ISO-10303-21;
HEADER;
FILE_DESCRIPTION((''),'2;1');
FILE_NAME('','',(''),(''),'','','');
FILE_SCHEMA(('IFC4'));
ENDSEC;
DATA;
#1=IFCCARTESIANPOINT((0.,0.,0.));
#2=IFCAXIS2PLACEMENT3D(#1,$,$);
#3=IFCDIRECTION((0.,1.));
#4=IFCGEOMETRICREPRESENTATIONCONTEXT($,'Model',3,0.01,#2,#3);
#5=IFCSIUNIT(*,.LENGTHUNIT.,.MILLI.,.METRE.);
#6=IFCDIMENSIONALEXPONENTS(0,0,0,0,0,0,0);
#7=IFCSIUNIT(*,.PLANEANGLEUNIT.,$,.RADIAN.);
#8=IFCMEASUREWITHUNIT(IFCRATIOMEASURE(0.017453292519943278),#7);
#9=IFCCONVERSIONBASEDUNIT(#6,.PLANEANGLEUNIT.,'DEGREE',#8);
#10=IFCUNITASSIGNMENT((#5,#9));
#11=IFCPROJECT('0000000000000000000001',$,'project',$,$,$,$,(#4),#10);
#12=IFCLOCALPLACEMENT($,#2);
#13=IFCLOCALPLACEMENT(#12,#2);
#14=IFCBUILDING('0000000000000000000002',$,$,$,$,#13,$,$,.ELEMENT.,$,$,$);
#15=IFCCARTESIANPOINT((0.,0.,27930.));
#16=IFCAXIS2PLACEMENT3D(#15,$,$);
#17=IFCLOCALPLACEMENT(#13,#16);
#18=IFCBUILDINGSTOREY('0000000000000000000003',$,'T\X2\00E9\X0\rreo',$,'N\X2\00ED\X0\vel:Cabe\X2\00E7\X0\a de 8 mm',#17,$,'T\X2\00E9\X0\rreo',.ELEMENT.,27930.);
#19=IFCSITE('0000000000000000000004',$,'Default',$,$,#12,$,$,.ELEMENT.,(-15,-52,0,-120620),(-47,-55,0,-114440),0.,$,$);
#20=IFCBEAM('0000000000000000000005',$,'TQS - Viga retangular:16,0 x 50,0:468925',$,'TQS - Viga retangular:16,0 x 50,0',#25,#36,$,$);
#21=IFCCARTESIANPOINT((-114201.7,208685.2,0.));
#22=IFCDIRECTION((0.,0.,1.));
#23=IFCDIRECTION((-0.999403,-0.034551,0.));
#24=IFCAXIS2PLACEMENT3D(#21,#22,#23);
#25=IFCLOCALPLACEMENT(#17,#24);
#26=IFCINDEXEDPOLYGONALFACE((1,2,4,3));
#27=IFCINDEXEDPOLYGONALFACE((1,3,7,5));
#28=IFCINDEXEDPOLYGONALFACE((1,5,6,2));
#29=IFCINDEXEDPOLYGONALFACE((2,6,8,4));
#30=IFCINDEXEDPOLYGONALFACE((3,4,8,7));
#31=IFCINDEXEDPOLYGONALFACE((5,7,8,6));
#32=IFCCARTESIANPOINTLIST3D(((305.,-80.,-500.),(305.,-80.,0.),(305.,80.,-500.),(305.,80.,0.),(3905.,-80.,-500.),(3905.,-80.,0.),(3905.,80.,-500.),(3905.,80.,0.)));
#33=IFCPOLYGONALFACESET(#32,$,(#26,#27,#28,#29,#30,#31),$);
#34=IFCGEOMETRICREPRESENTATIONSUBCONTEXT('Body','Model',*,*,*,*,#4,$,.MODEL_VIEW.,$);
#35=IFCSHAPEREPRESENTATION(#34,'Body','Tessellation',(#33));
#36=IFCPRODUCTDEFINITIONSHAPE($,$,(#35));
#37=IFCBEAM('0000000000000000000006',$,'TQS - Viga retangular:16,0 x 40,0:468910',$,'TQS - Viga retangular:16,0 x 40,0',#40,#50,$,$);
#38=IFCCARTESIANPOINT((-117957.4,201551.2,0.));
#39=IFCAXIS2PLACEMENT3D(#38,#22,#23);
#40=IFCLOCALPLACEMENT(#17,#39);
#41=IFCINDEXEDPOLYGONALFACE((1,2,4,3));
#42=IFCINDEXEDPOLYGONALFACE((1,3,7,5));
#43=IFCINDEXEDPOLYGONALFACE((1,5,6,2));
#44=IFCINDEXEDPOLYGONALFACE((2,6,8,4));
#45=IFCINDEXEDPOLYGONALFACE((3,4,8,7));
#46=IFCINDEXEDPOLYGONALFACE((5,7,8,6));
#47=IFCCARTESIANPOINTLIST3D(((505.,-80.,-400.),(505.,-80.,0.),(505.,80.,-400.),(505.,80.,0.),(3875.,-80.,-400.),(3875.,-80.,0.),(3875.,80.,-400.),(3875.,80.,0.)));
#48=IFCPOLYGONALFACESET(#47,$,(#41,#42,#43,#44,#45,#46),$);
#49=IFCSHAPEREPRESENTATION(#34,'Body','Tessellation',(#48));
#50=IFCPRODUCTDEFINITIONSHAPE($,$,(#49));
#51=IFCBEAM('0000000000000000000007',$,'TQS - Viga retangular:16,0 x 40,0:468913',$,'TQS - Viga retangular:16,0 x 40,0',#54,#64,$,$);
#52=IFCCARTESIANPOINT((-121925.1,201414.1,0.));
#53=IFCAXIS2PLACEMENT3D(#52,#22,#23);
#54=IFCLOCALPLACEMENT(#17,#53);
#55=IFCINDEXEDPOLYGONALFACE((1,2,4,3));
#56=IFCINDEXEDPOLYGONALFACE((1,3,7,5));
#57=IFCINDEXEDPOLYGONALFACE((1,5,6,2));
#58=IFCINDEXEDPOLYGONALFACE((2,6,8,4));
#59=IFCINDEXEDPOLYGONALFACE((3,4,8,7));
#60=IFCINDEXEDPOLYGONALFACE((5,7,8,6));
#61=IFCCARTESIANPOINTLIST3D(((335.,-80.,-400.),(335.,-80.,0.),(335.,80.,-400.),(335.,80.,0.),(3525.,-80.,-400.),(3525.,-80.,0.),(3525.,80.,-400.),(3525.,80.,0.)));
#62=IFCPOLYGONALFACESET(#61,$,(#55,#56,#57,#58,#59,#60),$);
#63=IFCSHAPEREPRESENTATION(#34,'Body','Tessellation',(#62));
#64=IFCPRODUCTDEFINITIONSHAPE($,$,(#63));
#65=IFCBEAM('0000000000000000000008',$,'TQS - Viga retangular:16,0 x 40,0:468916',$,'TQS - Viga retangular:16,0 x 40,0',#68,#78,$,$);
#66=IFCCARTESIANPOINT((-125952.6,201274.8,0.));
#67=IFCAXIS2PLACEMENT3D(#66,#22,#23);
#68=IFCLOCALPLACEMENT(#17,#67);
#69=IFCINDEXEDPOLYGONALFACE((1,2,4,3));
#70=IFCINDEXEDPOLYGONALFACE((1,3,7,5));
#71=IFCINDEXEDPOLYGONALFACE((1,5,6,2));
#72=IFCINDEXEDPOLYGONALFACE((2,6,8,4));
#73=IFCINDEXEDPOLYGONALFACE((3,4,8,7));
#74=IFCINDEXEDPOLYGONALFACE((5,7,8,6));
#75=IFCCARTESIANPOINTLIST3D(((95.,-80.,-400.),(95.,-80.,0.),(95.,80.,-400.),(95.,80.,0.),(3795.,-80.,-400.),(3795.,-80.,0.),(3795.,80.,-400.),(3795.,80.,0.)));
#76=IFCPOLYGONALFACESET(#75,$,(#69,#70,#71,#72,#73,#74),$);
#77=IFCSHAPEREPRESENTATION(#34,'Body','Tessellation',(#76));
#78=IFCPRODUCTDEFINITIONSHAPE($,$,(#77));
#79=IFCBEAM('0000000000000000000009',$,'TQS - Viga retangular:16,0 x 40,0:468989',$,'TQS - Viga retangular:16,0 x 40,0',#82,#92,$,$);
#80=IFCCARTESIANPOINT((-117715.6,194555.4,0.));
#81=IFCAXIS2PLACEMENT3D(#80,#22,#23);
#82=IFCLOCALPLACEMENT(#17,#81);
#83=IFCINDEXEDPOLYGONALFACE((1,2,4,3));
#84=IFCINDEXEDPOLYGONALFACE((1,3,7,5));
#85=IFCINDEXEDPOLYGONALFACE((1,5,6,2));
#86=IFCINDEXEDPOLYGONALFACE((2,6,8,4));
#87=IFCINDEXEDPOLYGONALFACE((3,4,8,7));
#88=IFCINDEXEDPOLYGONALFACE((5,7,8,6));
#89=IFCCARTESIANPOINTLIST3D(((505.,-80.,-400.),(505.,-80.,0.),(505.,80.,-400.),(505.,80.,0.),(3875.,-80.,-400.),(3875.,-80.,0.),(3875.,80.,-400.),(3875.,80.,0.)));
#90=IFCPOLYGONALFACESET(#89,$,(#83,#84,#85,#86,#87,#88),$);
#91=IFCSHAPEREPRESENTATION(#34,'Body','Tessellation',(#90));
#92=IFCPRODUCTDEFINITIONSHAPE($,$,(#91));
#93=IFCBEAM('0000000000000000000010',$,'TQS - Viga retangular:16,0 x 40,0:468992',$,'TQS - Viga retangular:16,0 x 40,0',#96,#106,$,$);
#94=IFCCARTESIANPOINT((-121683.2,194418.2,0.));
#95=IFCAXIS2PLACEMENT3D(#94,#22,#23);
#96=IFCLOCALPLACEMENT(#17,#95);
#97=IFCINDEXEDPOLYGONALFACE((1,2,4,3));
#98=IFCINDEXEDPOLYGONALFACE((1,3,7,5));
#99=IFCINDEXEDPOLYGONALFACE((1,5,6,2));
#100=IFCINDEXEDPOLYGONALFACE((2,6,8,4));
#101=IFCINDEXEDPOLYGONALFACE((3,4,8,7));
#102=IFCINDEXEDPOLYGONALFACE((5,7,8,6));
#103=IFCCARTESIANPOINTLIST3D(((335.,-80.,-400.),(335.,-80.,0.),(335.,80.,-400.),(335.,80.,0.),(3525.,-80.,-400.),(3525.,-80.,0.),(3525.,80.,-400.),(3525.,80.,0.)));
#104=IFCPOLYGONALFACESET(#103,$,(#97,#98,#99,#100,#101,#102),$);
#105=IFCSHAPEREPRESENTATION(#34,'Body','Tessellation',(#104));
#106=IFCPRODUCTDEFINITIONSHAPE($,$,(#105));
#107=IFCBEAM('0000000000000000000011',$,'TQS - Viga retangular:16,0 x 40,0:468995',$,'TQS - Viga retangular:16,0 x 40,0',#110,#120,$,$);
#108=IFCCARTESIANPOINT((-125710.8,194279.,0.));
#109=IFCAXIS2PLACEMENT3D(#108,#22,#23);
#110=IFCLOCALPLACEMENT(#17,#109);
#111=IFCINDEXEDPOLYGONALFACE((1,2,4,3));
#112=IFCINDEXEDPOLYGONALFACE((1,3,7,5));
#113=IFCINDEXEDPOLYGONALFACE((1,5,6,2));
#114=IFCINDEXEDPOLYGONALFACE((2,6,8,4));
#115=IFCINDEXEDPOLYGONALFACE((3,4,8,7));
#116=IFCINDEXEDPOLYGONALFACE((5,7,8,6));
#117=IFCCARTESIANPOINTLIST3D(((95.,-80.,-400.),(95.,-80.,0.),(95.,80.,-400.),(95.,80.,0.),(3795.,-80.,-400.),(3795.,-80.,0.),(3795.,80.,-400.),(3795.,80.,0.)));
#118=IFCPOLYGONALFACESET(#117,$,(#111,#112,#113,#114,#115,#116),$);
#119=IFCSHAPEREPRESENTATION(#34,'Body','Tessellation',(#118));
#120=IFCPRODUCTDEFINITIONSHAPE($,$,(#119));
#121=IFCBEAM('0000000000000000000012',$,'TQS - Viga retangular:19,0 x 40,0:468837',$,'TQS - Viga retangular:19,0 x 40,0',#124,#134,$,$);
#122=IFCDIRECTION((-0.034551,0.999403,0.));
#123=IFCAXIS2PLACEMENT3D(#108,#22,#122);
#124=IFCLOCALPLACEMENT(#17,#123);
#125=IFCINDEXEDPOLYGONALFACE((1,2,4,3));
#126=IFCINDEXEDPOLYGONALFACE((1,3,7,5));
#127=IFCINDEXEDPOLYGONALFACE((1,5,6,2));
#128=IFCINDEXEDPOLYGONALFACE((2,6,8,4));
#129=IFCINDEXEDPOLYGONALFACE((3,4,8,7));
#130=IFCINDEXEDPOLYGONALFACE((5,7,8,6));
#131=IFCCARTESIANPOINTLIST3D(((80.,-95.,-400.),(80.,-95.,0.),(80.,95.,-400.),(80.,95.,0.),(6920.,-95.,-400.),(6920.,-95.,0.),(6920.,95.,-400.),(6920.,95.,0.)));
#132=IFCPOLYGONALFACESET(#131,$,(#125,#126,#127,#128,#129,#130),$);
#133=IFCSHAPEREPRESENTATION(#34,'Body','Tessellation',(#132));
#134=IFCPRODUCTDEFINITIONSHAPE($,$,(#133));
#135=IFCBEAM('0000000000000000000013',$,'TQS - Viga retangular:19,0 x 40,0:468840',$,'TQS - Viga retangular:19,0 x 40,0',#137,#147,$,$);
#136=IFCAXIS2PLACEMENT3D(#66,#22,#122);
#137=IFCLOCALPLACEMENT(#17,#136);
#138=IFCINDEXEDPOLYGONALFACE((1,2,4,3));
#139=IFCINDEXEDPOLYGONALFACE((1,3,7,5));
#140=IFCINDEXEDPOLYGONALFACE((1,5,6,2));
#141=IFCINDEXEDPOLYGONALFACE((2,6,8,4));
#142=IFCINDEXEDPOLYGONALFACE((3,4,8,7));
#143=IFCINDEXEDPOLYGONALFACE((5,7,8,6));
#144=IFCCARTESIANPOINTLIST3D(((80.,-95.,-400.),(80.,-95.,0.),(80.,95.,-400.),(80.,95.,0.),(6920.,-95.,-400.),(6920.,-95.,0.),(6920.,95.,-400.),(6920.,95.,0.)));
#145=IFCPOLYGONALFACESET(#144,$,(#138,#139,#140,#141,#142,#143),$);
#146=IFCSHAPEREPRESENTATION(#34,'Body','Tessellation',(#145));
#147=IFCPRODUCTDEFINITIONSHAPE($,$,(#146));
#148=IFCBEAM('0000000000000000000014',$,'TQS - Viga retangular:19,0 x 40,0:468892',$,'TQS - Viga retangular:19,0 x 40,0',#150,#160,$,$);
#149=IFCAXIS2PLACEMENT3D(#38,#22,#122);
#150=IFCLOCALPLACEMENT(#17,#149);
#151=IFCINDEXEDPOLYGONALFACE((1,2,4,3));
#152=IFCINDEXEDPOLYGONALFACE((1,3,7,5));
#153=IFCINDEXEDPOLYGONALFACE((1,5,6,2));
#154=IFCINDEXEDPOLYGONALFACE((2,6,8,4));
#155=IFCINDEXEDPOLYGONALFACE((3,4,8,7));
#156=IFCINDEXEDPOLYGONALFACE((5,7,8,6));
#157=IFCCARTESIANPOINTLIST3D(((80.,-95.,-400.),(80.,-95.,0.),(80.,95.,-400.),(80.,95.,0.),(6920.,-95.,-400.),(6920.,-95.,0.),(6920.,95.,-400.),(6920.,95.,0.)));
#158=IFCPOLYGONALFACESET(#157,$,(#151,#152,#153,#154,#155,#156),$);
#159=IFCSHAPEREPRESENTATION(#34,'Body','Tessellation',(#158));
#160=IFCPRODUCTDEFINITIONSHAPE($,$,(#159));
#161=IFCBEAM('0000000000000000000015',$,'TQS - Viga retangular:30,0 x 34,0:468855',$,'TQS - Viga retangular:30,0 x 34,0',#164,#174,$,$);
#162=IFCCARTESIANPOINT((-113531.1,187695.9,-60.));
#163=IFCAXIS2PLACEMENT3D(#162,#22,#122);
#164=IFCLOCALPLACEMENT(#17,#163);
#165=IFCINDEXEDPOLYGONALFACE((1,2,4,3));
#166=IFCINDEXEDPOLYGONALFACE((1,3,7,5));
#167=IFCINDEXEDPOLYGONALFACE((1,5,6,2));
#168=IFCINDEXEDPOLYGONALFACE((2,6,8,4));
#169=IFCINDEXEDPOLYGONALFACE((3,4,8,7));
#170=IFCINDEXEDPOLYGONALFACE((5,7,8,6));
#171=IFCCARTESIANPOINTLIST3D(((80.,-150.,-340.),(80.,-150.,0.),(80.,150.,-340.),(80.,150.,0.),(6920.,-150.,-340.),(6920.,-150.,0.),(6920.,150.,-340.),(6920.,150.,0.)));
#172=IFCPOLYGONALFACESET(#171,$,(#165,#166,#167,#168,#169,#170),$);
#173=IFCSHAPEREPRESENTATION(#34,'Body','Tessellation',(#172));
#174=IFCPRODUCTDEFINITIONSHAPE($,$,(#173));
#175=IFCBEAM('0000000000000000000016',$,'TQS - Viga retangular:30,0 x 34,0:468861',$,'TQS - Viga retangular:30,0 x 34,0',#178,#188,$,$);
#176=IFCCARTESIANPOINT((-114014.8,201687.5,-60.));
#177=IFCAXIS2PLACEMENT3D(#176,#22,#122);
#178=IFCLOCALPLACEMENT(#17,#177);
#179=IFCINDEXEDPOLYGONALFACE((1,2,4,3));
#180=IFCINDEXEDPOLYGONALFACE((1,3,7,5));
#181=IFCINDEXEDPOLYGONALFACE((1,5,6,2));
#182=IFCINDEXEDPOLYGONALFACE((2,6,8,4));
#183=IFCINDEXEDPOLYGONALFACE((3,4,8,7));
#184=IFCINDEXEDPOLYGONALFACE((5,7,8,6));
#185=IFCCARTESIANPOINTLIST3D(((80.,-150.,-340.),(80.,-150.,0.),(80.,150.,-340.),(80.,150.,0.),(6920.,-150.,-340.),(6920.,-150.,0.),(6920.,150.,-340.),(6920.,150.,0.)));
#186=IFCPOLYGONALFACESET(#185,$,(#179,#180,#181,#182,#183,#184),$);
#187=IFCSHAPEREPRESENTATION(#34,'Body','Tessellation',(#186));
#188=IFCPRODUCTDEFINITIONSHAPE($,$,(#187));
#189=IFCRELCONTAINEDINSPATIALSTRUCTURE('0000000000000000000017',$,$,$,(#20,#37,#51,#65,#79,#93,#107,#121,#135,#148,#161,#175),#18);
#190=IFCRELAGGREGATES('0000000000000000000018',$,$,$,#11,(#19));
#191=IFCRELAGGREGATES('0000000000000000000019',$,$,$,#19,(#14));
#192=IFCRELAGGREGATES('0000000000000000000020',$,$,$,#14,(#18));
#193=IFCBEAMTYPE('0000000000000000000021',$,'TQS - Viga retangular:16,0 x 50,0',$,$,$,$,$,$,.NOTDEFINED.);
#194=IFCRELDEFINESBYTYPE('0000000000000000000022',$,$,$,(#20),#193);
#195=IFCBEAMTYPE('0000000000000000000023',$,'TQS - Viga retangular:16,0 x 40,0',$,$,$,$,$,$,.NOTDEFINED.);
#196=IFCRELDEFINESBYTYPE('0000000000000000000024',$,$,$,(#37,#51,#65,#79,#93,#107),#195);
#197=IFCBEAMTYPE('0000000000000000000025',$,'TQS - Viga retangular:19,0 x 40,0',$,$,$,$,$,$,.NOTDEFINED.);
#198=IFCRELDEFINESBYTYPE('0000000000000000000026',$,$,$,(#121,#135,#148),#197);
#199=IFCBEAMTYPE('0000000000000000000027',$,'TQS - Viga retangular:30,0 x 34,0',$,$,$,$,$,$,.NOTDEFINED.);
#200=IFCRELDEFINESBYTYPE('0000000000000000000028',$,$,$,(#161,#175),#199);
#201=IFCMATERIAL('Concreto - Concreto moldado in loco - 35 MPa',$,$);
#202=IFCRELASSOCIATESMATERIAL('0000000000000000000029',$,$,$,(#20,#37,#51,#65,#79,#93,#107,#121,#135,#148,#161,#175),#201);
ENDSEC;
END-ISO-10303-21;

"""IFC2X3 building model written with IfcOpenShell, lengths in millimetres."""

from ifc_helpers import new_model, entity, si_unit, converted_unit, direction, frame, frame_2d, origin, origin_2d_with_axis, place, context, subcontext, project, spatial, rectangle, extrude, material, type_object, element, save


model = new_model("IFC2X3")

# Units and contexts
model_context = context("Model", 3, precision=0.01, world=origin(), true_north=direction((0.0, 1.0)))
body_context = subcontext(model_context, "Body", "Model", "MODEL_VIEW")
ifc_project = project(units=[si_unit("LENGTHUNIT", "METRE", prefix="MILLI"), converted_unit("PLANEANGLEUNIT", "DEGREE", entity("IfcRatioMeasure", 0.017453292519943278), si_unit("PLANEANGLEUNIT", "RADIAN"), dimensions=[0, 0, 0, 0, 0, 0, 0])], contexts=[model_context])

# Site, building, storey
site_placement = place(None, origin())
site = spatial("IfcSite", under=ifc_project, at=site_placement, Name="Default", CompositionType="ELEMENT", RefLatitude=(-15, -52, 0, -120620), RefLongitude=(-47, -55, 0, -114440), RefElevation=0.0)
building_placement = place(site_placement, origin())
building = spatial("IfcBuilding", under=site, at=building_placement, CompositionType="ELEMENT")
storey_placement = place(building_placement, frame((0.0, 0.0, 27930.0)))
storey = spatial("IfcBuildingStorey", under=building, at=storey_placement, Name="Térreo", ObjectType="Nível:Cabeça de 8 mm", LongName="Térreo", CompositionType="ELEMENT", Elevation=27930.0)

# Beams
ifc_material_1 = material(Name="Concreto - Concreto moldado in loco - 35 MPa")
beam_type_1 = type_object("IfcBeamType", Name="TQS - Viga retangular:16,0 x 50,0", PredefinedType="NOTDEFINED")
beam_1_placement = place(storey_placement, frame((-114201.7, 208685.2, 0.0), z_axis=(0.0, 0.0, 1.0), x_axis=(-0.999403, -0.034551, 0.0)))
element("IfcBeam", 1, at=beam_1_placement, inside=storey, type_object=beam_type_1, material=ifc_material_1, Name="TQS - Viga retangular:16,0 x 50,0:468925", ObjectType="TQS - Viga retangular:16,0 x 50,0", context=body_context, shape_type="SweptSolid", body=[
    extrude(rectangle(XDim=500.0, YDim=160.0, at=origin_2d_with_axis()), frame((305.0, 0.0, -250.0), z_axis=(1.0, 0.0, 0.0), x_axis=(0.0, 0.0, -1.0)), (0.0, 0.0, 1.0), 3600.0),
])
beam_type_2 = type_object("IfcBeamType", Name="TQS - Viga retangular:16,0 x 40,0", PredefinedType="NOTDEFINED")
beam_2_placement = place(storey_placement, frame((-117957.4, 201551.2, 0.0), z_axis=(0.0, 0.0, 1.0), x_axis=(-0.999403, -0.034551, 0.0)))
element("IfcBeam", 2, at=beam_2_placement, inside=storey, type_object=beam_type_2, material=ifc_material_1, Name="TQS - Viga retangular:16,0 x 40,0:468910", ObjectType="TQS - Viga retangular:16,0 x 40,0", context=body_context, shape_type="SweptSolid", body=[
    extrude(rectangle(XDim=400.0, YDim=160.0, at=frame_2d((0.0, 0.0), x_axis=(1.0, 0.0))), frame((505.0, 0.0, -200.0), z_axis=(1.0, 0.0, 0.0), x_axis=(0.0, 0.0, -1.0)), (0.0, 0.0, 1.0), 3370.0),
])
beam_3_placement = place(storey_placement, frame((-121925.1, 201414.1, 0.0), z_axis=(0.0, 0.0, 1.0), x_axis=(-0.999403, -0.034551, 0.0)))
element("IfcBeam", 3, at=beam_3_placement, inside=storey, type_object=beam_type_2, material=ifc_material_1, Name="TQS - Viga retangular:16,0 x 40,0:468913", ObjectType="TQS - Viga retangular:16,0 x 40,0", context=body_context, shape_type="SweptSolid", body=[
    extrude(rectangle(XDim=400.0, YDim=160.0, at=frame_2d((0.0, 0.0), x_axis=(1.0, 0.0))), frame((335.0, 0.0, -200.0), z_axis=(1.0, 0.0, 0.0), x_axis=(0.0, 0.0, -1.0)), (0.0, 0.0, 1.0), 3190.0),
])
beam_4_placement = place(storey_placement, frame((-125952.6, 201274.8, 0.0), z_axis=(0.0, 0.0, 1.0), x_axis=(-0.999403, -0.034551, 0.0)))
element("IfcBeam", 4, at=beam_4_placement, inside=storey, type_object=beam_type_2, material=ifc_material_1, Name="TQS - Viga retangular:16,0 x 40,0:468916", ObjectType="TQS - Viga retangular:16,0 x 40,0", context=body_context, shape_type="SweptSolid", body=[
    extrude(rectangle(XDim=400.0, YDim=160.0, at=frame_2d((0.0, 0.0), x_axis=(1.0, 0.0))), frame((95.0, 0.0, -200.0), z_axis=(1.0, 0.0, 0.0), x_axis=(0.0, 0.0, -1.0)), (0.0, 0.0, 1.0), 3700.0),
])
beam_5_placement = place(storey_placement, frame((-117715.6, 194555.4, 0.0), z_axis=(0.0, 0.0, 1.0), x_axis=(-0.999403, -0.034551, 0.0)))
element("IfcBeam", 5, at=beam_5_placement, inside=storey, type_object=beam_type_2, material=ifc_material_1, Name="TQS - Viga retangular:16,0 x 40,0:468989", ObjectType="TQS - Viga retangular:16,0 x 40,0", context=body_context, shape_type="SweptSolid", body=[
    extrude(rectangle(XDim=400.0, YDim=160.0, at=frame_2d((0.0, 0.0), x_axis=(1.0, 0.0))), frame((505.0, 0.0, -200.0), z_axis=(1.0, 0.0, 0.0), x_axis=(0.0, 0.0, -1.0)), (0.0, 0.0, 1.0), 3370.0),
])
beam_6_placement = place(storey_placement, frame((-121683.2, 194418.2, 0.0), z_axis=(0.0, 0.0, 1.0), x_axis=(-0.999403, -0.034551, 0.0)))
element("IfcBeam", 6, at=beam_6_placement, inside=storey, type_object=beam_type_2, material=ifc_material_1, Name="TQS - Viga retangular:16,0 x 40,0:468992", ObjectType="TQS - Viga retangular:16,0 x 40,0", context=body_context, shape_type="SweptSolid", body=[
    extrude(rectangle(XDim=400.0, YDim=160.0, at=frame_2d((0.0, 0.0), x_axis=(1.0, 0.0))), frame((335.0, 0.0, -200.0), z_axis=(1.0, 0.0, 0.0), x_axis=(0.0, 0.0, -1.0)), (0.0, 0.0, 1.0), 3190.0),
])
beam_7_placement = place(storey_placement, frame((-125710.8, 194279.0, 0.0), z_axis=(0.0, 0.0, 1.0), x_axis=(-0.999403, -0.034551, 0.0)))
element("IfcBeam", 7, at=beam_7_placement, inside=storey, type_object=beam_type_2, material=ifc_material_1, Name="TQS - Viga retangular:16,0 x 40,0:468995", ObjectType="TQS - Viga retangular:16,0 x 40,0", context=body_context, shape_type="SweptSolid", body=[
    extrude(rectangle(XDim=400.0, YDim=160.0, at=frame_2d((0.0, 0.0), x_axis=(1.0, 0.0))), frame((95.0, 0.0, -200.0), z_axis=(1.0, 0.0, 0.0), x_axis=(0.0, 0.0, -1.0)), (0.0, 0.0, 1.0), 3700.0),
])
beam_type_3 = type_object("IfcBeamType", Name="TQS - Viga retangular:19,0 x 40,0", PredefinedType="NOTDEFINED")
beam_8_placement = place(storey_placement, frame((-125710.8, 194279.0, 0.0), z_axis=(0.0, 0.0, 1.0), x_axis=(-0.034551, 0.999403, 0.0)))
element("IfcBeam", 8, at=beam_8_placement, inside=storey, type_object=beam_type_3, material=ifc_material_1, Name="TQS - Viga retangular:19,0 x 40,0:468837", ObjectType="TQS - Viga retangular:19,0 x 40,0", context=body_context, shape_type="SweptSolid", body=[
    extrude(rectangle(XDim=400.0, YDim=190.0, at=frame_2d((0.0, 0.0), x_axis=(1.0, 0.0))), frame((80.0, 0.0, -200.0), z_axis=(1.0, 0.0, 0.0), x_axis=(0.0, 0.0, -1.0)), (0.0, 0.0, 1.0), 6840.0),
])
beam_9_placement = place(storey_placement, frame((-125952.6, 201274.8, 0.0), z_axis=(0.0, 0.0, 1.0), x_axis=(-0.034551, 0.999403, 0.0)))
element("IfcBeam", 9, at=beam_9_placement, inside=storey, type_object=beam_type_3, material=ifc_material_1, Name="TQS - Viga retangular:19,0 x 40,0:468840", ObjectType="TQS - Viga retangular:19,0 x 40,0", context=body_context, shape_type="SweptSolid", body=[
    extrude(rectangle(XDim=400.0, YDim=190.0, at=frame_2d((0.0, 0.0), x_axis=(1.0, 0.0))), frame((80.0, 0.0, -200.0), z_axis=(1.0, 0.0, 0.0), x_axis=(0.0, 0.0, -1.0)), (0.0, 0.0, 1.0), 6840.0),
])
beam_10_placement = place(storey_placement, frame((-117957.4, 201551.2, 0.0), z_axis=(0.0, 0.0, 1.0), x_axis=(-0.034551, 0.999403, 0.0)))
element("IfcBeam", 10, at=beam_10_placement, inside=storey, type_object=beam_type_3, material=ifc_material_1, Name="TQS - Viga retangular:19,0 x 40,0:468892", ObjectType="TQS - Viga retangular:19,0 x 40,0", context=body_context, shape_type="SweptSolid", body=[
    extrude(rectangle(XDim=400.0, YDim=190.0, at=frame_2d((0.0, 0.0), x_axis=(1.0, 0.0))), frame((80.0, 0.0, -200.0), z_axis=(1.0, 0.0, 0.0), x_axis=(0.0, 0.0, -1.0)), (0.0, 0.0, 1.0), 6840.0),
])
beam_type_4 = type_object("IfcBeamType", Name="TQS - Viga retangular:30,0 x 34,0", PredefinedType="NOTDEFINED")
beam_11_placement = place(storey_placement, frame((-113531.1, 187695.9, -60.0), z_axis=(0.0, 0.0, 1.0), x_axis=(-0.034551, 0.999403, 0.0)))
element("IfcBeam", 11, at=beam_11_placement, inside=storey, type_object=beam_type_4, material=ifc_material_1, Name="TQS - Viga retangular:30,0 x 34,0:468855", ObjectType="TQS - Viga retangular:30,0 x 34,0", context=body_context, shape_type="SweptSolid", body=[
    extrude(rectangle(XDim=340.0, YDim=300.0, at=frame_2d((0.0, 0.0), x_axis=(1.0, 0.0))), frame((80.0, 0.0, -170.0), z_axis=(1.0, 0.0, 0.0), x_axis=(0.0, 0.0, -1.0)), (0.0, 0.0, 1.0), 6840.0),
])
beam_12_placement = place(storey_placement, frame((-114014.8, 201687.5, -60.0), z_axis=(0.0, 0.0, 1.0), x_axis=(-0.034551, 0.999403, 0.0)))
element("IfcBeam", 12, at=beam_12_placement, inside=storey, type_object=beam_type_4, material=ifc_material_1, Name="TQS - Viga retangular:30,0 x 34,0:468861", ObjectType="TQS - Viga retangular:30,0 x 34,0", context=body_context, shape_type="SweptSolid", body=[
    extrude(rectangle(XDim=340.0, YDim=300.0, at=frame_2d((0.0, 0.0), x_axis=(1.0, 0.0))), frame((80.0, 0.0, -170.0), z_axis=(1.0, 0.0, 0.0), x_axis=(0.0, 0.0, -1.0)), (0.0, 0.0, 1.0), 6840.0),
])

save(model, "model.ifc")
